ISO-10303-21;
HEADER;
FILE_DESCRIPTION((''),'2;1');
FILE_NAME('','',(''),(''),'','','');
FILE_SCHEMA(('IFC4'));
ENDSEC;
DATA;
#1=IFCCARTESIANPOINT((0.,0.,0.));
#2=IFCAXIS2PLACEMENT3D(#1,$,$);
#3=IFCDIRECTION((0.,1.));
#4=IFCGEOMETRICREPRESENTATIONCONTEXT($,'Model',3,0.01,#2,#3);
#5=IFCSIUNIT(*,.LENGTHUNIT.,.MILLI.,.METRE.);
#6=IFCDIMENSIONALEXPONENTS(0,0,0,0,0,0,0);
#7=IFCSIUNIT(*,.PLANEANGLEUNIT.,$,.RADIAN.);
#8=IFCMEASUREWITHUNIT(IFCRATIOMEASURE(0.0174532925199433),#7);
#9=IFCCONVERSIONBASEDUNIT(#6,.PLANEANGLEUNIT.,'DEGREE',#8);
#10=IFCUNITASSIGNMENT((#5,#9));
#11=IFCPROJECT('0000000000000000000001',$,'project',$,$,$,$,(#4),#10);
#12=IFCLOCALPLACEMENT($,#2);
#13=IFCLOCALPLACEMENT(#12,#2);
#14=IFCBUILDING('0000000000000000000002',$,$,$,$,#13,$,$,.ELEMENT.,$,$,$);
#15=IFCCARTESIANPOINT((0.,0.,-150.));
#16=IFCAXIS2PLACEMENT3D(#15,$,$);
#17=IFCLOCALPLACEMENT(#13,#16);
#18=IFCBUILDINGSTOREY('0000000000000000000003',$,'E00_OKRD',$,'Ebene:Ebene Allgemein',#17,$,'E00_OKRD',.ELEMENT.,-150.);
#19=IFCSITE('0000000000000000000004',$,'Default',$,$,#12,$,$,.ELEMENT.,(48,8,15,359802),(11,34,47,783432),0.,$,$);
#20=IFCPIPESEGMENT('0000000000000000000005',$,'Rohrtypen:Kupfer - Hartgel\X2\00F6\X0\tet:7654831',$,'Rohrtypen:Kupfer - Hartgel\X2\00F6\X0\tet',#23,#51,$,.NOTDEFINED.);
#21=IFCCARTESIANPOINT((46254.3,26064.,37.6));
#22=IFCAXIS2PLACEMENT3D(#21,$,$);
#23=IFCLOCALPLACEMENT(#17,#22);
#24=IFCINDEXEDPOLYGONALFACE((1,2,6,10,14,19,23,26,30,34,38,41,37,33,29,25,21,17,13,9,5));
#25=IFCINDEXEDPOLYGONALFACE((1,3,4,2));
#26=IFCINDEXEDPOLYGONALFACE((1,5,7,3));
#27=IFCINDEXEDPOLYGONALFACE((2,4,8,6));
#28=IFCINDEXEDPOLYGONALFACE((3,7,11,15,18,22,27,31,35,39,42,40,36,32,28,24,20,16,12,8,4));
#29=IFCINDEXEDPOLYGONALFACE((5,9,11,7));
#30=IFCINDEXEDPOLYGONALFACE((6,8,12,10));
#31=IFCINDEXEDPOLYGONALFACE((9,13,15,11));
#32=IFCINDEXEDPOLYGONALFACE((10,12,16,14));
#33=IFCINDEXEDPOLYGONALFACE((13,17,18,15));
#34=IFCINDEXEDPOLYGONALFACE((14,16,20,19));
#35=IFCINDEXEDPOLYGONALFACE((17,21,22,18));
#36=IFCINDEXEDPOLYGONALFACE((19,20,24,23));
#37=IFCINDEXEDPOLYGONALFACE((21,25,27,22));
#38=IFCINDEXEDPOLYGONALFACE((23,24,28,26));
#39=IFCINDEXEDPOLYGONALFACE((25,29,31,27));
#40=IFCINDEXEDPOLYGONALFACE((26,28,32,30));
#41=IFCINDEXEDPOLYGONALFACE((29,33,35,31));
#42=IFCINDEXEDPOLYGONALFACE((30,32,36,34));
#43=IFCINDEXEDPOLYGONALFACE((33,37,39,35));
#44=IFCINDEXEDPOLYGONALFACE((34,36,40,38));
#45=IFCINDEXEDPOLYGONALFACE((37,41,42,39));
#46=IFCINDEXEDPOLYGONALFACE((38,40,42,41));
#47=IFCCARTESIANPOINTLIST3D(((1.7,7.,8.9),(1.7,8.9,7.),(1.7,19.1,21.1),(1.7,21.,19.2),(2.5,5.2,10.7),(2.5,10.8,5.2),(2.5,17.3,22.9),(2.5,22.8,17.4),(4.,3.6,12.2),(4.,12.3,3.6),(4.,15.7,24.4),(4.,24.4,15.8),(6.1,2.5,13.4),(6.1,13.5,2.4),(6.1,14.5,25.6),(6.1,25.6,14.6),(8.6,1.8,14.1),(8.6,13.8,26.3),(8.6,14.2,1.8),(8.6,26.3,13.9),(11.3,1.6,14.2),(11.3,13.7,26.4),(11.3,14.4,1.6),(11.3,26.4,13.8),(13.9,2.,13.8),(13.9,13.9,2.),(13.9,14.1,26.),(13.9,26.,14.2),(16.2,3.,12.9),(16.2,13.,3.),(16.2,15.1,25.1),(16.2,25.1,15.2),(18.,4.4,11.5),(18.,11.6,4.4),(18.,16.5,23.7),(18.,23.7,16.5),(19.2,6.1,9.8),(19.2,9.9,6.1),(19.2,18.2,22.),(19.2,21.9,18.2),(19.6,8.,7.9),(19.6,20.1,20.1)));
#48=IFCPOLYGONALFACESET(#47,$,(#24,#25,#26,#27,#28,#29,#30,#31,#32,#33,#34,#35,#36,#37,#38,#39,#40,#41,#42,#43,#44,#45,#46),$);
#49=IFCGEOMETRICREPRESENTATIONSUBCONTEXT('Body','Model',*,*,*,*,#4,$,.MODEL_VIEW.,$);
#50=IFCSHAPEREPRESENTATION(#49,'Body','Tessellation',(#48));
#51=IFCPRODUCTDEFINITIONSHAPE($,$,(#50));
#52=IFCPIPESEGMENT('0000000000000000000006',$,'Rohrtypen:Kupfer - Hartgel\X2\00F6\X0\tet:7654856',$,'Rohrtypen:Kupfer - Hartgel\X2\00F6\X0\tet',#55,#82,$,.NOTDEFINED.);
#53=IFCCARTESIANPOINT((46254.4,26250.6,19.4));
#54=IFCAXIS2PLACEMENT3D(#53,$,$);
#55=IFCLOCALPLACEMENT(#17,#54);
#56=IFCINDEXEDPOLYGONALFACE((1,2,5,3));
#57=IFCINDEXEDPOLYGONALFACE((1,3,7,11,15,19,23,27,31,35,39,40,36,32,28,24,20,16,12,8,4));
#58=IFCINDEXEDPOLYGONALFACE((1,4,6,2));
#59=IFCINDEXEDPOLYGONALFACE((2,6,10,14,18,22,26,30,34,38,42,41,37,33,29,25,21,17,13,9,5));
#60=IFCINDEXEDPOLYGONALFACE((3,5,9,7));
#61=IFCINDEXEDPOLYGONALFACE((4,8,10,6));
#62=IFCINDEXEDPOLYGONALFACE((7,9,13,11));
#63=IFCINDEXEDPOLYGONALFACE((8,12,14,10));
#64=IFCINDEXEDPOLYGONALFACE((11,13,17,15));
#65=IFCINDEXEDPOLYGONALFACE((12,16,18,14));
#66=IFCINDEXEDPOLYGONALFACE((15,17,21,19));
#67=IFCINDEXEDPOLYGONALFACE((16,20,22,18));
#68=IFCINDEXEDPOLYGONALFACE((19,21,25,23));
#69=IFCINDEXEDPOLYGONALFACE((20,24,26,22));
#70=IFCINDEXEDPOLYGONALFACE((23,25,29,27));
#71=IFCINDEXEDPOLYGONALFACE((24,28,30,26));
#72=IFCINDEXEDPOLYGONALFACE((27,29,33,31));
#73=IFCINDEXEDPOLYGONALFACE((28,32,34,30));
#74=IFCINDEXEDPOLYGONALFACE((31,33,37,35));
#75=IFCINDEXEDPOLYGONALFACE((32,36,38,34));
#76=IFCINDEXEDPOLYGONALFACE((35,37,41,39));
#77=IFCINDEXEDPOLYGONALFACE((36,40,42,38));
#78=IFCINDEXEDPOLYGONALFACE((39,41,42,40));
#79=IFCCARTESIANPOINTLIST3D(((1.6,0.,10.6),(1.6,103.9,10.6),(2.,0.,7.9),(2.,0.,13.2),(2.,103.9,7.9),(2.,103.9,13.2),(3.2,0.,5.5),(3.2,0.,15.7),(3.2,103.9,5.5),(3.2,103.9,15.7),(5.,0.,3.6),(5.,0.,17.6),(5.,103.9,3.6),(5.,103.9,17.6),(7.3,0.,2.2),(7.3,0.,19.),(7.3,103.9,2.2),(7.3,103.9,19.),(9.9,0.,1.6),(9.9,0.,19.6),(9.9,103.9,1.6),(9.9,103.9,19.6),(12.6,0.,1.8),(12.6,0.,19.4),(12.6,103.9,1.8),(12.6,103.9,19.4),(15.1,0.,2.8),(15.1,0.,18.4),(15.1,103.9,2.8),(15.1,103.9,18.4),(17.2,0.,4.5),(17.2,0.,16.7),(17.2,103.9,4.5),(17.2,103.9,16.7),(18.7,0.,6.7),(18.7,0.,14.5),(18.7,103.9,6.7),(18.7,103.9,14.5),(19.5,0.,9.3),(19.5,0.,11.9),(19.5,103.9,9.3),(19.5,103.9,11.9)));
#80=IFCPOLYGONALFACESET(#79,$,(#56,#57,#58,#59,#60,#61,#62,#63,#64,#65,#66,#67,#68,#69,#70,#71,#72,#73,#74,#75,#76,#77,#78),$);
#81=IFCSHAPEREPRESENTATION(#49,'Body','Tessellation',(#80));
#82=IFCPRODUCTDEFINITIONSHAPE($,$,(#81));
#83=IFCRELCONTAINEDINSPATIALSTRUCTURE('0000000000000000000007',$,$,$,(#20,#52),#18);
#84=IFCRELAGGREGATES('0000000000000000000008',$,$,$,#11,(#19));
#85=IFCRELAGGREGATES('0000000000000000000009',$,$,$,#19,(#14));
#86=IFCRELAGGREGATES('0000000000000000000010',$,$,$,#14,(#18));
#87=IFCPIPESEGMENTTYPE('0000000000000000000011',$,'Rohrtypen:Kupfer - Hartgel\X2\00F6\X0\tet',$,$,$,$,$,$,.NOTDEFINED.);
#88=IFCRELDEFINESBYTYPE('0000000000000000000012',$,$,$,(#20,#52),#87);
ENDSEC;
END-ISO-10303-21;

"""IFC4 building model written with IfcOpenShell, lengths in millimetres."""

from ifc_helpers import new_model, entity, si_unit, converted_unit, direction, frame, frame_2d, origin, origin_2d_with_axis, place, context, subcontext, project, spatial, circle, extrude, type_object, element, save


model = new_model("IFC4")

# Units and contexts
model_context = context("Model", 3, precision=0.01, world=origin(), true_north=direction((0.0, 1.0)))
body_context = subcontext(model_context, "Body", "Model", "MODEL_VIEW")
ifc_project = project(units=[si_unit("LENGTHUNIT", "METRE", prefix="MILLI"), converted_unit("PLANEANGLEUNIT", "DEGREE", entity("IfcRatioMeasure", 0.0174532925199433), si_unit("PLANEANGLEUNIT", "RADIAN"), dimensions=[0, 0, 0, 0, 0, 0, 0])], contexts=[model_context])

# Site, building, storey
site_placement = place(None, origin())
site = spatial("IfcSite", under=ifc_project, at=site_placement, Name="Default", CompositionType="ELEMENT", RefLatitude=(48, 8, 15, 359802), RefLongitude=(11, 34, 47, 783432), RefElevation=0.0)
building_placement = place(site_placement, origin())
building = spatial("IfcBuilding", under=site, at=building_placement, CompositionType="ELEMENT")
storey_placement = place(building_placement, frame((0.0, 0.0, -150.0)))
storey = spatial("IfcBuildingStorey", under=building, at=storey_placement, Name="E00_OKRD", ObjectType="Ebene:Ebene Allgemein", LongName="E00_OKRD", CompositionType="ELEMENT", Elevation=-150.0)

# Pipe segments
pipe_segment_type = type_object("IfcPipeSegmentType", Name="Rohrtypen:Kupfer - Hartgelötet", PredefinedType="NOTDEFINED")
pipe_segment_1_placement = place(storey_placement, frame((46254.3, 26064.0, 37.6)))
element("IfcPipeSegment", 1, at=pipe_segment_1_placement, inside=storey, type_object=pipe_segment_type, Name="Rohrtypen:Kupfer - Hartgelötet:7654831", ObjectType="Rohrtypen:Kupfer - Hartgelötet", PredefinedType="NOTDEFINED", context=body_context, shape_type="SweptSolid", body=[
    extrude(circle(Radius=9.0, at=frame_2d((0.0, 0.0), x_axis=(1.0, 0.0))), frame((10.6, 8.0, 7.9), z_axis=(0.0, 0.70394, 0.71026), x_axis=(1.0, 0.0, 0.0)), (0.0, 0.0, 1.0), 17.1),
])
pipe_segment_2_placement = place(storey_placement, frame((46254.4, 26250.6, 19.4)))
element("IfcPipeSegment", 2, at=pipe_segment_2_placement, inside=storey, type_object=pipe_segment_type, Name="Rohrtypen:Kupfer - Hartgelötet:7654856", ObjectType="Rohrtypen:Kupfer - Hartgelötet", PredefinedType="NOTDEFINED", context=body_context, shape_type="SweptSolid", body=[
    extrude(circle(Radius=9.0, at=origin_2d_with_axis()), frame((10.6, 0.0, 10.6), z_axis=(0.0, 1.0, 0.0), x_axis=(-1.0, 0.0, 0.0)), (0.0, 0.0, 1.0), 103.9),
])

save(model, "model.ifc")
